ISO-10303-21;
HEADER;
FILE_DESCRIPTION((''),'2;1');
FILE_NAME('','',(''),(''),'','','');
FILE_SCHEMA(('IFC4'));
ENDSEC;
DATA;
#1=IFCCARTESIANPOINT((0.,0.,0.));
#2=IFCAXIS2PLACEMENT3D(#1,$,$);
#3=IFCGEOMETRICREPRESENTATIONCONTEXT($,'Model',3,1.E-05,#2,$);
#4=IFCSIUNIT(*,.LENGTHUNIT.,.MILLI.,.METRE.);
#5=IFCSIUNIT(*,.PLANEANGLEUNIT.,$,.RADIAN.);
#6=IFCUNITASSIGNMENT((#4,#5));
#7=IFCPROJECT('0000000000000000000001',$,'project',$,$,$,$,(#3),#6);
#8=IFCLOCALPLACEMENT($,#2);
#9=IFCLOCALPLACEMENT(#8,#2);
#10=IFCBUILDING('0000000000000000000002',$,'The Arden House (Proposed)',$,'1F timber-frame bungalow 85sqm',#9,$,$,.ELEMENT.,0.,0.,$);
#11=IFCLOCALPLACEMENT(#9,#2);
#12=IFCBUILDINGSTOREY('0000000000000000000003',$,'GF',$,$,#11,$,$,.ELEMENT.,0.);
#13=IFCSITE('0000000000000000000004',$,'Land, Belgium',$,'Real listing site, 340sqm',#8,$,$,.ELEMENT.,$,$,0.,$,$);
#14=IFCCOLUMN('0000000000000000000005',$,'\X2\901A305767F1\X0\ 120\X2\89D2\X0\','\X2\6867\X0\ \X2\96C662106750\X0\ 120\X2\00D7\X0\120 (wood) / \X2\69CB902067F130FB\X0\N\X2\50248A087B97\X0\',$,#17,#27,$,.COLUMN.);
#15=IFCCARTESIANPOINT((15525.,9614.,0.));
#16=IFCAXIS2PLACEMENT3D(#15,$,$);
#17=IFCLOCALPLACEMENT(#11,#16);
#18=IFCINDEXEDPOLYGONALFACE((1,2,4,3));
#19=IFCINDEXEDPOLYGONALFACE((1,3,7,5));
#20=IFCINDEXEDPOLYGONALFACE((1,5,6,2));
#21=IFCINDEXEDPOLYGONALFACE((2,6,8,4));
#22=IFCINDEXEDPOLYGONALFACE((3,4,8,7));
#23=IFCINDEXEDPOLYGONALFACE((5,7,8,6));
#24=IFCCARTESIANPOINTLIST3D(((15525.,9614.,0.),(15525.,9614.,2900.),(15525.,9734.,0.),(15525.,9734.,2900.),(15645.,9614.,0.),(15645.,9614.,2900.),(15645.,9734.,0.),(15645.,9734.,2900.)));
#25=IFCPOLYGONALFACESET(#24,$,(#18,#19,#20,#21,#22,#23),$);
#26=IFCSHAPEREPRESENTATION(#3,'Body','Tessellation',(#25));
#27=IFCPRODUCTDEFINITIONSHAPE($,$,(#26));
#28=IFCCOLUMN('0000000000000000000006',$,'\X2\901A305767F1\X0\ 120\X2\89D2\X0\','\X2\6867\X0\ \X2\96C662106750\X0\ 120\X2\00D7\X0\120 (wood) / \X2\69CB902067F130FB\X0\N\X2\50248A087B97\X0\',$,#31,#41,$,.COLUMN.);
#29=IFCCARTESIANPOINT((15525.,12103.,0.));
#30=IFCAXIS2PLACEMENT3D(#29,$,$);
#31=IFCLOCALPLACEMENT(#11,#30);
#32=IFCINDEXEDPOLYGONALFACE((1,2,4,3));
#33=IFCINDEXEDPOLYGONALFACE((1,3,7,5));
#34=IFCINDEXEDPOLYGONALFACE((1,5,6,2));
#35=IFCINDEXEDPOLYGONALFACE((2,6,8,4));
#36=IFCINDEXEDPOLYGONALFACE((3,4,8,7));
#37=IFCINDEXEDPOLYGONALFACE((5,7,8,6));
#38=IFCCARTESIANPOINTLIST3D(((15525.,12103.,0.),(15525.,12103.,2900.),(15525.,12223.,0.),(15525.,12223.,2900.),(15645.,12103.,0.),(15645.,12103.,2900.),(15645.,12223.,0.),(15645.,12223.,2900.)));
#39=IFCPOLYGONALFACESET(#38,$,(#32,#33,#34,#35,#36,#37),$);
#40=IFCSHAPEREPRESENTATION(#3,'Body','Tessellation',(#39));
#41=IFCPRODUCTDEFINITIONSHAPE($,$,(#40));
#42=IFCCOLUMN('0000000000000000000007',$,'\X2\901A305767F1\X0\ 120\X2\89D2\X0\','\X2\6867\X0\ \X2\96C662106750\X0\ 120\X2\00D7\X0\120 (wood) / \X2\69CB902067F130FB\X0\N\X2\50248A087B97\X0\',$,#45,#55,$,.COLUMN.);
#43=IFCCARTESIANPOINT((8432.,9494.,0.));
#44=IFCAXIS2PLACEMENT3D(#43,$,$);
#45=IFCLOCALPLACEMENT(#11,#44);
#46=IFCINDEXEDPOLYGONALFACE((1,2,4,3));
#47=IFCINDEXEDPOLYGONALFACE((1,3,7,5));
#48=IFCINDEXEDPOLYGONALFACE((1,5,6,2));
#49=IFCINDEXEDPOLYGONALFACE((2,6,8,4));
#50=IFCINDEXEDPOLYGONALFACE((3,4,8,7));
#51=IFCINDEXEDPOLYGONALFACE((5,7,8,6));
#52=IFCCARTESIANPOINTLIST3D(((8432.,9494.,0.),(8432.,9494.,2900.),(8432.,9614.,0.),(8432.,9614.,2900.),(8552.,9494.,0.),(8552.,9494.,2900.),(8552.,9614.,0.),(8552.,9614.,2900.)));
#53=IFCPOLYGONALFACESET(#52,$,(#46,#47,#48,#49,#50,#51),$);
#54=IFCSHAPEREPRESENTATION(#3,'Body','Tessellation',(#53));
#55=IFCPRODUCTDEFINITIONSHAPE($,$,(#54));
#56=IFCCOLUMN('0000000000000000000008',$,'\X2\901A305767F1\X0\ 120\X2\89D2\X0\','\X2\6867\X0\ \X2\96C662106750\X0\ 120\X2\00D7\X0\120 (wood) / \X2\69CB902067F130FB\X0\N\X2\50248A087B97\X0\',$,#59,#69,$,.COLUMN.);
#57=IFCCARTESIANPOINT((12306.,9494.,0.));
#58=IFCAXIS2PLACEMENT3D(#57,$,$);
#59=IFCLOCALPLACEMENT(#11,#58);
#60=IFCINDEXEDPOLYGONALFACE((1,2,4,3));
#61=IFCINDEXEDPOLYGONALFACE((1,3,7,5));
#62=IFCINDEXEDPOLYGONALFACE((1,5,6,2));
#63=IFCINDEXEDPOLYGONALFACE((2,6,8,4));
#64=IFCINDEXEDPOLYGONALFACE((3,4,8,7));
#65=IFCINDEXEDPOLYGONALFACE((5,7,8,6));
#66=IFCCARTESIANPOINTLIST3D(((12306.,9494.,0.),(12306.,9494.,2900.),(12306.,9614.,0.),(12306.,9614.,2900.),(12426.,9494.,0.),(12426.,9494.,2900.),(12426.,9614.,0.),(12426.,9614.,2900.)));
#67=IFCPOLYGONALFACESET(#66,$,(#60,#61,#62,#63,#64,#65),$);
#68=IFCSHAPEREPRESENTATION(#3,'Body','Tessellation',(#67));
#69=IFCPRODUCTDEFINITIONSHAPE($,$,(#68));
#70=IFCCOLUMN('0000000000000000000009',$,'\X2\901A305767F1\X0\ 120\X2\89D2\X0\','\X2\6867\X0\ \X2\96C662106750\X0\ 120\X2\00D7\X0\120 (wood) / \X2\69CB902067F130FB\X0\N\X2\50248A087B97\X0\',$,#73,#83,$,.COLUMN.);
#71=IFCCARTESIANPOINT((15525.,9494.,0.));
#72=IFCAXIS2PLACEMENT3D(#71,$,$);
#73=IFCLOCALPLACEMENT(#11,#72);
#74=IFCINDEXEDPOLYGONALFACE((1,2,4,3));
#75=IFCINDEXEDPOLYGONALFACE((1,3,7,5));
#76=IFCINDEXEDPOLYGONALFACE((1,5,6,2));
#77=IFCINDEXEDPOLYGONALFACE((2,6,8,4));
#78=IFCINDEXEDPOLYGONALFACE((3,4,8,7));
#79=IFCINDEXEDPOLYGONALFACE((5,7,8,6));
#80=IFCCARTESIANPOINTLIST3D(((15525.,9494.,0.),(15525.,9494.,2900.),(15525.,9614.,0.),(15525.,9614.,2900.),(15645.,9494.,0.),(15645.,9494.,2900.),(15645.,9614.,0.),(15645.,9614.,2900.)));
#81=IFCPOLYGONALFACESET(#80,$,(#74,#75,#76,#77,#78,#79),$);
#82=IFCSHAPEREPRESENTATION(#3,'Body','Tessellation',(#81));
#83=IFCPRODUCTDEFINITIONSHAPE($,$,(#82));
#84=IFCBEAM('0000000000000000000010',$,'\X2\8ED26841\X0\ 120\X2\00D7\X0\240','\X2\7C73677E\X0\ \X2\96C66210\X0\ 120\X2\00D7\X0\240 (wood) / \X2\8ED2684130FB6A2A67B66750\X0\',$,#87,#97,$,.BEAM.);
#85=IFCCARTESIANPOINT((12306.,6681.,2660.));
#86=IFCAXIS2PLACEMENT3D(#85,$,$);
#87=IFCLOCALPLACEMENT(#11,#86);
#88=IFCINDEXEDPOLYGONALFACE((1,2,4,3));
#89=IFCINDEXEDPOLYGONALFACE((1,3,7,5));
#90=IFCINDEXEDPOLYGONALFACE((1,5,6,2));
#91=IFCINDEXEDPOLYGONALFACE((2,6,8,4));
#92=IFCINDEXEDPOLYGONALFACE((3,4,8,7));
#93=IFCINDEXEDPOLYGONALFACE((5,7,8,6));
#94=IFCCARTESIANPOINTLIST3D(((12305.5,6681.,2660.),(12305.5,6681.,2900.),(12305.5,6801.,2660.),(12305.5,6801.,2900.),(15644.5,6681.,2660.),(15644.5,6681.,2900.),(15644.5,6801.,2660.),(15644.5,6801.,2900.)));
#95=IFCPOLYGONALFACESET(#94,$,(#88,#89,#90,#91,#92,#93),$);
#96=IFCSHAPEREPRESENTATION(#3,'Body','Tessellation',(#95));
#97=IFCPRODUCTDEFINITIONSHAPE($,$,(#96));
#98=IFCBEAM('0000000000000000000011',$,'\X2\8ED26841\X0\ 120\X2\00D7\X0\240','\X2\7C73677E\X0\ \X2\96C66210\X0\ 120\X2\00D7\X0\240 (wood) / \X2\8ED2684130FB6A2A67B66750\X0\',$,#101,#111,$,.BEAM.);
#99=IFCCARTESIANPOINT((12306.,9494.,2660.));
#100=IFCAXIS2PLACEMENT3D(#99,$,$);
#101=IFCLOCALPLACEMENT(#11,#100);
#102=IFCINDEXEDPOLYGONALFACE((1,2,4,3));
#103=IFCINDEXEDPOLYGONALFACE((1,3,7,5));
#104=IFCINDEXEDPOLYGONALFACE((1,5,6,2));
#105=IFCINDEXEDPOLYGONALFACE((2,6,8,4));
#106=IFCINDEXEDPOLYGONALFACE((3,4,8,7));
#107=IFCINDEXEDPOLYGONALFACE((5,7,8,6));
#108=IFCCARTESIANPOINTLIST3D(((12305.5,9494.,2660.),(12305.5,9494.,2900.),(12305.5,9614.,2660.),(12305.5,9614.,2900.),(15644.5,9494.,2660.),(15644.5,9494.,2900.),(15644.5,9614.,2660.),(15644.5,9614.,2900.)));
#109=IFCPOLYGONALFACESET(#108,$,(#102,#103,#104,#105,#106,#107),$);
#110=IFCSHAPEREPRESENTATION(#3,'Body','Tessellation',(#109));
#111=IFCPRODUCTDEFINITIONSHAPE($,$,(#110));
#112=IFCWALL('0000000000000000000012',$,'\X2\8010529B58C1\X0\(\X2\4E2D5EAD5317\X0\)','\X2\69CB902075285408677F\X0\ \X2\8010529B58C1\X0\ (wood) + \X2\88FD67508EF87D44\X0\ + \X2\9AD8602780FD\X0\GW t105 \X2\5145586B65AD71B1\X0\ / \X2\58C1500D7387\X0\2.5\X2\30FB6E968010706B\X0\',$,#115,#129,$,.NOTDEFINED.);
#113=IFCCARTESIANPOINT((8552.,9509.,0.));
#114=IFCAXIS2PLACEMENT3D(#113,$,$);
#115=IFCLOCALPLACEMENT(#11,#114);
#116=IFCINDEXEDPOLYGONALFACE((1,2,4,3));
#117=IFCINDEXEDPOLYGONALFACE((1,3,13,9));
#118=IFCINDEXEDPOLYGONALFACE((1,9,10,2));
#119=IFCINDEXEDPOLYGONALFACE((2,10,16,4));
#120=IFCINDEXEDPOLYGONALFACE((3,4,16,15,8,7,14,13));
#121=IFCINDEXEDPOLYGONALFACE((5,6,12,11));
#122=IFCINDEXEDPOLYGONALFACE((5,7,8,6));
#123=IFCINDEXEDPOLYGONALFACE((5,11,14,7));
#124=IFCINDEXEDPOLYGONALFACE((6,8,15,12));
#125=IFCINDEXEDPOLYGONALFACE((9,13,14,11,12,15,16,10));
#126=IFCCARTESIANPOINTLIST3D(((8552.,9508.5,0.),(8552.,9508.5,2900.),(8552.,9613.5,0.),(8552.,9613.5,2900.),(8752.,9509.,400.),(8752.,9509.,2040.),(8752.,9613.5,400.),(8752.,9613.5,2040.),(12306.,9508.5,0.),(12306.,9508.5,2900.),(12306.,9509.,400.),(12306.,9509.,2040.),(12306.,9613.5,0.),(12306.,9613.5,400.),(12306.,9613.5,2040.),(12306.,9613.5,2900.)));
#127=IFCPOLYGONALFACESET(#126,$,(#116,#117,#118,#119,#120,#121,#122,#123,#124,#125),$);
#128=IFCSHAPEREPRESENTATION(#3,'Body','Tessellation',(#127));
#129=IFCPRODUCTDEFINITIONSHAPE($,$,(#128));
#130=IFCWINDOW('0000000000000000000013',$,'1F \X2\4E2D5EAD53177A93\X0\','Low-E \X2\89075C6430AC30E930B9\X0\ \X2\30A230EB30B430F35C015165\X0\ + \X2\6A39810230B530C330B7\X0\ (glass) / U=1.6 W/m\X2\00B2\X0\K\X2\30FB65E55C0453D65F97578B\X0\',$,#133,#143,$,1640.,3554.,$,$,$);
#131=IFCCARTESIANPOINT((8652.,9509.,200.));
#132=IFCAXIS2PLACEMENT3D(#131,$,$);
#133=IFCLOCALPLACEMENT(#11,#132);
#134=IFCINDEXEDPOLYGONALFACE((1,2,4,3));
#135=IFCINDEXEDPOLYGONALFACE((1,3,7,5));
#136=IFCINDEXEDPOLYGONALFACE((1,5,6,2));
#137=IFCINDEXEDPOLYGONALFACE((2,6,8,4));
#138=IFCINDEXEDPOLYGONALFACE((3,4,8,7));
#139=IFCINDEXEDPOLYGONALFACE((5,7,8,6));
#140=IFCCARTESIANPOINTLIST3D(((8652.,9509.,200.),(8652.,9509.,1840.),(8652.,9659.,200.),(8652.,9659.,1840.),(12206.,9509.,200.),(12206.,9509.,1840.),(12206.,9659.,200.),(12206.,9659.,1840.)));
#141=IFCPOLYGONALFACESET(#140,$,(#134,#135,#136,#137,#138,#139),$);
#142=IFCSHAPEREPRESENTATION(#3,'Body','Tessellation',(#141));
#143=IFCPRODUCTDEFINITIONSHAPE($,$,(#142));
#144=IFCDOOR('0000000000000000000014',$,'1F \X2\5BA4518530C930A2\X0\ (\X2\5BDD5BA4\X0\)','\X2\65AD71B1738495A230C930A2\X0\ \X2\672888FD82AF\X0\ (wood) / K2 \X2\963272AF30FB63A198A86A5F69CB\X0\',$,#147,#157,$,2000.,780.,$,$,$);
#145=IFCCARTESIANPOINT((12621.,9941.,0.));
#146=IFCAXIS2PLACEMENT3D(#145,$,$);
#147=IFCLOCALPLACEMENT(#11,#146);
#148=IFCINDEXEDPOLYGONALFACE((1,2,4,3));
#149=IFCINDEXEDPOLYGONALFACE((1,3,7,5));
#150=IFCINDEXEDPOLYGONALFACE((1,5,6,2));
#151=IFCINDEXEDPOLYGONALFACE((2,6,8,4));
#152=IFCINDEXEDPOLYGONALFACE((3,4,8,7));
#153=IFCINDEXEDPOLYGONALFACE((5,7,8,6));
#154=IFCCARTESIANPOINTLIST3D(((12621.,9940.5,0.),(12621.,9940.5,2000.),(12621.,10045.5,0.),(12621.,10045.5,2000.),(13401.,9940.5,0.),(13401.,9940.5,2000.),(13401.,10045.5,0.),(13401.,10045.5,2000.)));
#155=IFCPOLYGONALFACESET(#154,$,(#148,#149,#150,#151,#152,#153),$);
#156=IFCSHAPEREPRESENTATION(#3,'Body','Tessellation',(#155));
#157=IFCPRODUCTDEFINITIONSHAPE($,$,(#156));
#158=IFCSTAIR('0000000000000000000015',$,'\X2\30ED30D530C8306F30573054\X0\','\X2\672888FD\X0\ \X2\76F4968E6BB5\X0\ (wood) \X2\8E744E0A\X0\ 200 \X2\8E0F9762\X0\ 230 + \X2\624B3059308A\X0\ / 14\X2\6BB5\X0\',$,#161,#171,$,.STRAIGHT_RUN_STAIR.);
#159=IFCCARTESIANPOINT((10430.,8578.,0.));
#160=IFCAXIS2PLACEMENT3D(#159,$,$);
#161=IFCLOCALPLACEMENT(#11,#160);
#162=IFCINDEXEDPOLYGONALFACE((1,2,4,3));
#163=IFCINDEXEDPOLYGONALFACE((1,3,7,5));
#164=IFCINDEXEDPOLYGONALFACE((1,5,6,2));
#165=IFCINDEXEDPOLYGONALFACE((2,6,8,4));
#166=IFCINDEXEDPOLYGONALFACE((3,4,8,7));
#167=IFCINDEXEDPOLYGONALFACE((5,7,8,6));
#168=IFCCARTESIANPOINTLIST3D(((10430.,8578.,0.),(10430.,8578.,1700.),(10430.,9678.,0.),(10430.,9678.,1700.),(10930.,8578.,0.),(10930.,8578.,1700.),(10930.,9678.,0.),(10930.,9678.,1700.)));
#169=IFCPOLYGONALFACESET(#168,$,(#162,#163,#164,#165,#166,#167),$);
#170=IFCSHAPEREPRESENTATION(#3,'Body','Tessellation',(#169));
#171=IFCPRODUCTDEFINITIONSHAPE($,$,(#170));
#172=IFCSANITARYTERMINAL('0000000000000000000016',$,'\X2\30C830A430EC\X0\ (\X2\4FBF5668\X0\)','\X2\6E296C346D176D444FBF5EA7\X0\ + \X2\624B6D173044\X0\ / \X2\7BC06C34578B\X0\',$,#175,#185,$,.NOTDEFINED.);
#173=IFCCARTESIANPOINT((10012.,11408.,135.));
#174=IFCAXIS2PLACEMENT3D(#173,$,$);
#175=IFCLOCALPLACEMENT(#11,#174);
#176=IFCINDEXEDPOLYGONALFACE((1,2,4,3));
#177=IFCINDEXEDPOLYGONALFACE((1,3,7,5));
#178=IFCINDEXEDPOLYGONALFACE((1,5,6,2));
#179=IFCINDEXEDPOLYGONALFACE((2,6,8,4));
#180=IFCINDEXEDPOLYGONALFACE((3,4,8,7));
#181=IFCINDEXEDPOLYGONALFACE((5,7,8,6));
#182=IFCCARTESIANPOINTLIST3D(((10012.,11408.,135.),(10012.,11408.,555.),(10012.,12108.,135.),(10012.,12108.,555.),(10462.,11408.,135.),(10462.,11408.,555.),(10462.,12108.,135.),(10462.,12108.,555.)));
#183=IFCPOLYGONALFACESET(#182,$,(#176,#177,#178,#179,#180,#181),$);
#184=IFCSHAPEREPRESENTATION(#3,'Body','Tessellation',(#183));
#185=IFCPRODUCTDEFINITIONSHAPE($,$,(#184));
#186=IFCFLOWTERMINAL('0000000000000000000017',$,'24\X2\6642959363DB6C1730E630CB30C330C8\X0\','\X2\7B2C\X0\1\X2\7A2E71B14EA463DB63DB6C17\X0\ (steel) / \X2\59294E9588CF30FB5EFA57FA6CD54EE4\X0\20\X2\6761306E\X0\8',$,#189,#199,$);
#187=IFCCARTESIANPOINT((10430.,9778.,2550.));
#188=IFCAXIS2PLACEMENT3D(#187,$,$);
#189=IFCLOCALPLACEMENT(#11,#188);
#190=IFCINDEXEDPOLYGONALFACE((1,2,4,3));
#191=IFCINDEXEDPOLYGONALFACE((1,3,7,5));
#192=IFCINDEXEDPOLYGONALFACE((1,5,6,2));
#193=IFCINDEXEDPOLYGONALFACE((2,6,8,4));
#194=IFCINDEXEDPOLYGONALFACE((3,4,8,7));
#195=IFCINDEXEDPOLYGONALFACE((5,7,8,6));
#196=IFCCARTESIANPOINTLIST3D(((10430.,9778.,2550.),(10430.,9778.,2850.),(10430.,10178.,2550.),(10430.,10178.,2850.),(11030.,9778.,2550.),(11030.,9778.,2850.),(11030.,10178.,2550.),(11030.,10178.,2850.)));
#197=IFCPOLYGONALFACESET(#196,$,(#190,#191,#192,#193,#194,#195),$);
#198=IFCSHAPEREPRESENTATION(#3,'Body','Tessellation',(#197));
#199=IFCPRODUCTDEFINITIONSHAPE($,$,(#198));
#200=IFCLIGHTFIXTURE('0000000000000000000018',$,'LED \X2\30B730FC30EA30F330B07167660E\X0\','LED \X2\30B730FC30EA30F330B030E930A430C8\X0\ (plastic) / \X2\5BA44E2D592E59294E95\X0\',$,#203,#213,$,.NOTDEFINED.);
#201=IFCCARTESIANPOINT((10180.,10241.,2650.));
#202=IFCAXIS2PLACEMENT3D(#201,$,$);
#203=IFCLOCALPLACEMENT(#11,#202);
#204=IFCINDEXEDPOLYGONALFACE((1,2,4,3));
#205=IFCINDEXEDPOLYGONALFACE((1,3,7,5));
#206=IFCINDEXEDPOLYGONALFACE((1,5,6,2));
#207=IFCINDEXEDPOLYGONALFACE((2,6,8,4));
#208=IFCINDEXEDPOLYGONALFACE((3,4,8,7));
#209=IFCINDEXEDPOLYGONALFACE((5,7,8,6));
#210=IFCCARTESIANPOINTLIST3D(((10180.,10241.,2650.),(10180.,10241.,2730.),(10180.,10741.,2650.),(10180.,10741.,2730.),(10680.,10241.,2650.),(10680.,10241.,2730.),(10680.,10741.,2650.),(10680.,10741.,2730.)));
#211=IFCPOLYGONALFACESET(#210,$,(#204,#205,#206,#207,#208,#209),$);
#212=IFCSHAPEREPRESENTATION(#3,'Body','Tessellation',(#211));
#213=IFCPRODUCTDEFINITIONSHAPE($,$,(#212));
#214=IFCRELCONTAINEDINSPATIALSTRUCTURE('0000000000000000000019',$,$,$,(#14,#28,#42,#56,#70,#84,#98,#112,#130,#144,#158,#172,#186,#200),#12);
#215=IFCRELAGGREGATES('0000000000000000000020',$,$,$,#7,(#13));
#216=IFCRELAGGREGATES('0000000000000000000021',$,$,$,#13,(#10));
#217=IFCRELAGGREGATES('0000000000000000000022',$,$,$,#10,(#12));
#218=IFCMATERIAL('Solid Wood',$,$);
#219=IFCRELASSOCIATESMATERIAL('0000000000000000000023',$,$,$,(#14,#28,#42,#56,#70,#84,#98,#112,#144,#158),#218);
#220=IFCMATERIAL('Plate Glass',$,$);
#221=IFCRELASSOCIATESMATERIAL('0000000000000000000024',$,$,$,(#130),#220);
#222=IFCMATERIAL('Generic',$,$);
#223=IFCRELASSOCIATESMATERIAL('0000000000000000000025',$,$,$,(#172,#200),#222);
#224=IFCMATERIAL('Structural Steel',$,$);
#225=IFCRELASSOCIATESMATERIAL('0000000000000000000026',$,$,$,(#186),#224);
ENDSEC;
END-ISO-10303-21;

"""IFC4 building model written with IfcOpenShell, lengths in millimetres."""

from ifc_helpers import new_model, si_unit, frame, frame_2d, origin, place, context, project, spatial, rectangle, extrude, material, element, fill, save


model = new_model("IFC4")

# Units and contexts
model_context = context("Model", 3, precision=1e-05, world=origin())
ifc_project = project(units=[si_unit("LENGTHUNIT", "METRE", prefix="MILLI"), si_unit("PLANEANGLEUNIT", "RADIAN")], contexts=[model_context])

# Site, building, storey
site_placement = place(None, origin())
site = spatial("IfcSite", under=ifc_project, at=site_placement, Name="Land, Belgium", ObjectType="Real listing site, 340sqm", CompositionType="ELEMENT", RefElevation=0.0)
building_placement = place(site_placement, origin())
building = spatial("IfcBuilding", under=site, at=building_placement, Name="The Arden House (Proposed)", ObjectType="1F timber-frame bungalow 85sqm", CompositionType="ELEMENT", ElevationOfRefHeight=0.0, ElevationOfTerrain=0.0)
storey_placement = place(building_placement, origin())
storey = spatial("IfcBuildingStorey", under=building, at=storey_placement, Name="GF", CompositionType="ELEMENT", Elevation=0.0)

# Columns
ifc_material_1 = material(Name="Solid Wood")
column_1_placement = place(storey_placement, frame((15525.0, 9614.0, 0.0)))
element("IfcColumn", 1, at=column_1_placement, inside=storey, material=ifc_material_1, Name="通し柱 120角", Description="桧 集成材 120×120 (wood) / 構造柱・N値計算", PredefinedType="COLUMN", context=model_context, shape_type="SweptSolid", body=[
    extrude(rectangle(XDim=120.0, YDim=120.0, at=frame_2d((60.0, 60.0))), frame((15525.0, 9614.0, 0.0)), (0.0, 0.0, 1.0), 2900.0),
])
column_2_placement = place(storey_placement, frame((15525.0, 12103.0, 0.0)))
element("IfcColumn", 2, at=column_2_placement, inside=storey, material=ifc_material_1, Name="通し柱 120角", Description="桧 集成材 120×120 (wood) / 構造柱・N値計算", PredefinedType="COLUMN", context=model_context, shape_type="SweptSolid", body=[
    extrude(rectangle(XDim=120.0, YDim=120.0, at=frame_2d((60.0, 60.0))), frame((15525.0, 12103.0, 0.0)), (0.0, 0.0, 1.0), 2900.0),
])
column_3_placement = place(storey_placement, frame((8432.0, 9494.0, 0.0)))
element("IfcColumn", 3, at=column_3_placement, inside=storey, material=ifc_material_1, Name="通し柱 120角", Description="桧 集成材 120×120 (wood) / 構造柱・N値計算", PredefinedType="COLUMN", context=model_context, shape_type="SweptSolid", body=[
    extrude(rectangle(XDim=120.0, YDim=120.0, at=frame_2d((60.0, 60.0))), frame((8432.0, 9494.0, 0.0)), (0.0, 0.0, 1.0), 2900.0),
])
column_4_placement = place(storey_placement, frame((12306.0, 9494.0, 0.0)))
element("IfcColumn", 4, at=column_4_placement, inside=storey, material=ifc_material_1, Name="通し柱 120角", Description="桧 集成材 120×120 (wood) / 構造柱・N値計算", PredefinedType="COLUMN", context=model_context, shape_type="SweptSolid", body=[
    extrude(rectangle(XDim=120.0, YDim=120.0, at=frame_2d((60.0, 60.0))), frame((12306.0, 9494.0, 0.0)), (0.0, 0.0, 1.0), 2900.0),
])
column_5_placement = place(storey_placement, frame((15525.0, 9494.0, 0.0)))
element("IfcColumn", 5, at=column_5_placement, inside=storey, material=ifc_material_1, Name="通し柱 120角", Description="桧 集成材 120×120 (wood) / 構造柱・N値計算", PredefinedType="COLUMN", context=model_context, shape_type="SweptSolid", body=[
    extrude(rectangle(XDim=120.0, YDim=120.0, at=frame_2d((60.0, 60.0))), frame((15525.0, 9494.0, 0.0)), (0.0, 0.0, 1.0), 2900.0),
])

# Beams
beam_1_placement = place(storey_placement, frame((12306.0, 6681.0, 2660.0)))
element("IfcBeam", 6, at=beam_1_placement, inside=storey, material=ifc_material_1, Name="軒桁 120×240", Description="米松 集成 120×240 (wood) / 軒桁・横架材", PredefinedType="BEAM", context=model_context, shape_type="SweptSolid", body=[
    extrude(rectangle(XDim=3339.0, YDim=120.0, at=frame_2d((1669.0, 60.0))), frame((12306.0, 6681.0, 2660.0)), (0.0, 0.0, 1.0), 240.0),
])
beam_2_placement = place(storey_placement, frame((12306.0, 9494.0, 2660.0)))
element("IfcBeam", 7, at=beam_2_placement, inside=storey, material=ifc_material_1, Name="軒桁 120×240", Description="米松 集成 120×240 (wood) / 軒桁・横架材", PredefinedType="BEAM", context=model_context, shape_type="SweptSolid", body=[
    extrude(rectangle(XDim=3339.0, YDim=120.0, at=frame_2d((1669.0, 60.0))), frame((12306.0, 9494.0, 2660.0)), (0.0, 0.0, 1.0), 240.0),
])

# Wall, opening, window
wall_1_placement = place(storey_placement, frame((8552.0, 9509.0, 0.0)))
wall_1 = element("IfcWall", 8, at=wall_1_placement, inside=storey, material=ifc_material_1, Name="耐力壁(中庭北)", Description="構造用合板 耐力壁 (wood) + 製材軸組 + 高性能GW t105 充填断熱 / 壁倍率2.5・準耐火", PredefinedType="NOTDEFINED", context=model_context, shape_type="SweptSolid", body=[
    extrude(rectangle(XDim=3754.0, YDim=105.0, at=frame_2d((1877.0, 52.0))), frame((8552.0, 9509.0, 0.0)), (0.0, 0.0, 1.0), 2900.0),
])
opening_placement = place(storey_placement, frame((8652.0, 9509.0, 200.0)))
opening = element("IfcOpeningElement", 9, at=opening_placement, cuts=wall_1, PredefinedType="NOTDEFINED", context=model_context, shape_type="SweptSolid", body=[
    extrude(rectangle(XDim=3554.0, YDim=150.0, at=frame_2d((1777.0, 75.0))), frame((8652.0, 9509.0, 200.0)), (0.0, 0.0, 1.0), 1640.0),
])
ifc_material_2 = material(Name="Plate Glass")
window_placement = place(storey_placement, frame((8652.0, 9509.0, 200.0)))
window = element("IfcWindow", 10, at=window_placement, inside=storey, material=ifc_material_2, Name="1F 中庭北窓", Description="Low-E 複層ガラス アルゴン封入 + 樹脂サッシ (glass) / U=1.6 W/m²K・日射取得型", OverallHeight=1640.0, OverallWidth=3554.0, context=model_context, shape_type="SweptSolid", body=[
    extrude(rectangle(XDim=3554.0, YDim=150.0, at=frame_2d((1777.0, 75.0))), frame((8652.0, 9509.0, 200.0)), (0.0, 0.0, 1.0), 1640.0),
])
fill(opening, window)

# Door
door_placement = place(storey_placement, frame((12621.0, 9941.0, 0.0)))
element("IfcDoor", 11, at=door_placement, inside=storey, material=ifc_material_1, Name="1F 室内ドア (寝室)", Description="断熱玄関ドア 木製芯 (wood) / K2 防犯・採風機構", OverallHeight=2000.0, OverallWidth=780.0, context=model_context, shape_type="SweptSolid", body=[
    extrude(rectangle(XDim=780.0, YDim=105.0, at=frame_2d((390.0, 52.0))), frame((12621.0, 9941.0, 0.0)), (0.0, 0.0, 1.0), 2000.0),
])

# Stair
stair_placement = place(storey_placement, frame((10430.0, 8578.0, 0.0)))
element("IfcStair", 12, at=stair_placement, inside=storey, material=ifc_material_1, Name="ロフトはしご", Description="木製 直階段 (wood) 蹴上 200 踏面 230 + 手すり / 14段", PredefinedType="STRAIGHT_RUN_STAIR", context=model_context, shape_type="SweptSolid", body=[
    extrude(rectangle(XDim=500.0, YDim=1100.0, at=frame_2d((250.0, 550.0))), frame((10430.0, 8578.0, 0.0)), (0.0, 0.0, 1.0), 1700.0),
])

# Shared definitions
ifc_material_3 = material(Name="Generic")

# Sanitary terminal
sanitary_terminal_placement = place(storey_placement, frame((10012.0, 11408.0, 135.0)))
element("IfcSanitaryTerminal", 13, at=sanitary_terminal_placement, inside=storey, material=ifc_material_3, Name="トイレ (便器)", Description="温水洗浄便座 + 手洗い / 節水型", PredefinedType="NOTDEFINED", context=model_context, shape_type="SweptSolid", body=[
    extrude(rectangle(XDim=450.0, YDim=700.0, at=frame_2d((225.0, 350.0))), frame((10012.0, 11408.0, 135.0)), (0.0, 0.0, 1.0), 420.0),
])

# Flow terminal
ifc_material_4 = material(Name="Structural Steel")
flow_terminal_placement = place(storey_placement, frame((10430.0, 9778.0, 2550.0)))
element("IfcFlowTerminal", 14, at=flow_terminal_placement, inside=storey, material=ifc_material_4, Name="24時間換気ユニット", Description="第1種熱交換換気 (steel) / 天井裏・建基法令20条の8", context=model_context, shape_type="SweptSolid", body=[
    extrude(rectangle(XDim=600.0, YDim=400.0, at=frame_2d((300.0, 200.0))), frame((10430.0, 9778.0, 2550.0)), (0.0, 0.0, 1.0), 300.0),
])

# Light fixture
light_fixture_1_placement = place(storey_placement, frame((10180.0, 10241.0, 2650.0)))
element("IfcLightFixture", 15, at=light_fixture_1_placement, inside=storey, material=ifc_material_3, Name="LED シーリング照明", Description="LED シーリングライト (plastic) / 室中央天井", PredefinedType="NOTDEFINED", context=model_context, shape_type="SweptSolid", body=[
    extrude(rectangle(XDim=500.0, YDim=500.0, at=frame_2d((250.0, 250.0))), frame((10180.0, 10241.0, 2650.0)), (0.0, 0.0, 1.0), 80.0),
])

save(model, "model.ifc")
